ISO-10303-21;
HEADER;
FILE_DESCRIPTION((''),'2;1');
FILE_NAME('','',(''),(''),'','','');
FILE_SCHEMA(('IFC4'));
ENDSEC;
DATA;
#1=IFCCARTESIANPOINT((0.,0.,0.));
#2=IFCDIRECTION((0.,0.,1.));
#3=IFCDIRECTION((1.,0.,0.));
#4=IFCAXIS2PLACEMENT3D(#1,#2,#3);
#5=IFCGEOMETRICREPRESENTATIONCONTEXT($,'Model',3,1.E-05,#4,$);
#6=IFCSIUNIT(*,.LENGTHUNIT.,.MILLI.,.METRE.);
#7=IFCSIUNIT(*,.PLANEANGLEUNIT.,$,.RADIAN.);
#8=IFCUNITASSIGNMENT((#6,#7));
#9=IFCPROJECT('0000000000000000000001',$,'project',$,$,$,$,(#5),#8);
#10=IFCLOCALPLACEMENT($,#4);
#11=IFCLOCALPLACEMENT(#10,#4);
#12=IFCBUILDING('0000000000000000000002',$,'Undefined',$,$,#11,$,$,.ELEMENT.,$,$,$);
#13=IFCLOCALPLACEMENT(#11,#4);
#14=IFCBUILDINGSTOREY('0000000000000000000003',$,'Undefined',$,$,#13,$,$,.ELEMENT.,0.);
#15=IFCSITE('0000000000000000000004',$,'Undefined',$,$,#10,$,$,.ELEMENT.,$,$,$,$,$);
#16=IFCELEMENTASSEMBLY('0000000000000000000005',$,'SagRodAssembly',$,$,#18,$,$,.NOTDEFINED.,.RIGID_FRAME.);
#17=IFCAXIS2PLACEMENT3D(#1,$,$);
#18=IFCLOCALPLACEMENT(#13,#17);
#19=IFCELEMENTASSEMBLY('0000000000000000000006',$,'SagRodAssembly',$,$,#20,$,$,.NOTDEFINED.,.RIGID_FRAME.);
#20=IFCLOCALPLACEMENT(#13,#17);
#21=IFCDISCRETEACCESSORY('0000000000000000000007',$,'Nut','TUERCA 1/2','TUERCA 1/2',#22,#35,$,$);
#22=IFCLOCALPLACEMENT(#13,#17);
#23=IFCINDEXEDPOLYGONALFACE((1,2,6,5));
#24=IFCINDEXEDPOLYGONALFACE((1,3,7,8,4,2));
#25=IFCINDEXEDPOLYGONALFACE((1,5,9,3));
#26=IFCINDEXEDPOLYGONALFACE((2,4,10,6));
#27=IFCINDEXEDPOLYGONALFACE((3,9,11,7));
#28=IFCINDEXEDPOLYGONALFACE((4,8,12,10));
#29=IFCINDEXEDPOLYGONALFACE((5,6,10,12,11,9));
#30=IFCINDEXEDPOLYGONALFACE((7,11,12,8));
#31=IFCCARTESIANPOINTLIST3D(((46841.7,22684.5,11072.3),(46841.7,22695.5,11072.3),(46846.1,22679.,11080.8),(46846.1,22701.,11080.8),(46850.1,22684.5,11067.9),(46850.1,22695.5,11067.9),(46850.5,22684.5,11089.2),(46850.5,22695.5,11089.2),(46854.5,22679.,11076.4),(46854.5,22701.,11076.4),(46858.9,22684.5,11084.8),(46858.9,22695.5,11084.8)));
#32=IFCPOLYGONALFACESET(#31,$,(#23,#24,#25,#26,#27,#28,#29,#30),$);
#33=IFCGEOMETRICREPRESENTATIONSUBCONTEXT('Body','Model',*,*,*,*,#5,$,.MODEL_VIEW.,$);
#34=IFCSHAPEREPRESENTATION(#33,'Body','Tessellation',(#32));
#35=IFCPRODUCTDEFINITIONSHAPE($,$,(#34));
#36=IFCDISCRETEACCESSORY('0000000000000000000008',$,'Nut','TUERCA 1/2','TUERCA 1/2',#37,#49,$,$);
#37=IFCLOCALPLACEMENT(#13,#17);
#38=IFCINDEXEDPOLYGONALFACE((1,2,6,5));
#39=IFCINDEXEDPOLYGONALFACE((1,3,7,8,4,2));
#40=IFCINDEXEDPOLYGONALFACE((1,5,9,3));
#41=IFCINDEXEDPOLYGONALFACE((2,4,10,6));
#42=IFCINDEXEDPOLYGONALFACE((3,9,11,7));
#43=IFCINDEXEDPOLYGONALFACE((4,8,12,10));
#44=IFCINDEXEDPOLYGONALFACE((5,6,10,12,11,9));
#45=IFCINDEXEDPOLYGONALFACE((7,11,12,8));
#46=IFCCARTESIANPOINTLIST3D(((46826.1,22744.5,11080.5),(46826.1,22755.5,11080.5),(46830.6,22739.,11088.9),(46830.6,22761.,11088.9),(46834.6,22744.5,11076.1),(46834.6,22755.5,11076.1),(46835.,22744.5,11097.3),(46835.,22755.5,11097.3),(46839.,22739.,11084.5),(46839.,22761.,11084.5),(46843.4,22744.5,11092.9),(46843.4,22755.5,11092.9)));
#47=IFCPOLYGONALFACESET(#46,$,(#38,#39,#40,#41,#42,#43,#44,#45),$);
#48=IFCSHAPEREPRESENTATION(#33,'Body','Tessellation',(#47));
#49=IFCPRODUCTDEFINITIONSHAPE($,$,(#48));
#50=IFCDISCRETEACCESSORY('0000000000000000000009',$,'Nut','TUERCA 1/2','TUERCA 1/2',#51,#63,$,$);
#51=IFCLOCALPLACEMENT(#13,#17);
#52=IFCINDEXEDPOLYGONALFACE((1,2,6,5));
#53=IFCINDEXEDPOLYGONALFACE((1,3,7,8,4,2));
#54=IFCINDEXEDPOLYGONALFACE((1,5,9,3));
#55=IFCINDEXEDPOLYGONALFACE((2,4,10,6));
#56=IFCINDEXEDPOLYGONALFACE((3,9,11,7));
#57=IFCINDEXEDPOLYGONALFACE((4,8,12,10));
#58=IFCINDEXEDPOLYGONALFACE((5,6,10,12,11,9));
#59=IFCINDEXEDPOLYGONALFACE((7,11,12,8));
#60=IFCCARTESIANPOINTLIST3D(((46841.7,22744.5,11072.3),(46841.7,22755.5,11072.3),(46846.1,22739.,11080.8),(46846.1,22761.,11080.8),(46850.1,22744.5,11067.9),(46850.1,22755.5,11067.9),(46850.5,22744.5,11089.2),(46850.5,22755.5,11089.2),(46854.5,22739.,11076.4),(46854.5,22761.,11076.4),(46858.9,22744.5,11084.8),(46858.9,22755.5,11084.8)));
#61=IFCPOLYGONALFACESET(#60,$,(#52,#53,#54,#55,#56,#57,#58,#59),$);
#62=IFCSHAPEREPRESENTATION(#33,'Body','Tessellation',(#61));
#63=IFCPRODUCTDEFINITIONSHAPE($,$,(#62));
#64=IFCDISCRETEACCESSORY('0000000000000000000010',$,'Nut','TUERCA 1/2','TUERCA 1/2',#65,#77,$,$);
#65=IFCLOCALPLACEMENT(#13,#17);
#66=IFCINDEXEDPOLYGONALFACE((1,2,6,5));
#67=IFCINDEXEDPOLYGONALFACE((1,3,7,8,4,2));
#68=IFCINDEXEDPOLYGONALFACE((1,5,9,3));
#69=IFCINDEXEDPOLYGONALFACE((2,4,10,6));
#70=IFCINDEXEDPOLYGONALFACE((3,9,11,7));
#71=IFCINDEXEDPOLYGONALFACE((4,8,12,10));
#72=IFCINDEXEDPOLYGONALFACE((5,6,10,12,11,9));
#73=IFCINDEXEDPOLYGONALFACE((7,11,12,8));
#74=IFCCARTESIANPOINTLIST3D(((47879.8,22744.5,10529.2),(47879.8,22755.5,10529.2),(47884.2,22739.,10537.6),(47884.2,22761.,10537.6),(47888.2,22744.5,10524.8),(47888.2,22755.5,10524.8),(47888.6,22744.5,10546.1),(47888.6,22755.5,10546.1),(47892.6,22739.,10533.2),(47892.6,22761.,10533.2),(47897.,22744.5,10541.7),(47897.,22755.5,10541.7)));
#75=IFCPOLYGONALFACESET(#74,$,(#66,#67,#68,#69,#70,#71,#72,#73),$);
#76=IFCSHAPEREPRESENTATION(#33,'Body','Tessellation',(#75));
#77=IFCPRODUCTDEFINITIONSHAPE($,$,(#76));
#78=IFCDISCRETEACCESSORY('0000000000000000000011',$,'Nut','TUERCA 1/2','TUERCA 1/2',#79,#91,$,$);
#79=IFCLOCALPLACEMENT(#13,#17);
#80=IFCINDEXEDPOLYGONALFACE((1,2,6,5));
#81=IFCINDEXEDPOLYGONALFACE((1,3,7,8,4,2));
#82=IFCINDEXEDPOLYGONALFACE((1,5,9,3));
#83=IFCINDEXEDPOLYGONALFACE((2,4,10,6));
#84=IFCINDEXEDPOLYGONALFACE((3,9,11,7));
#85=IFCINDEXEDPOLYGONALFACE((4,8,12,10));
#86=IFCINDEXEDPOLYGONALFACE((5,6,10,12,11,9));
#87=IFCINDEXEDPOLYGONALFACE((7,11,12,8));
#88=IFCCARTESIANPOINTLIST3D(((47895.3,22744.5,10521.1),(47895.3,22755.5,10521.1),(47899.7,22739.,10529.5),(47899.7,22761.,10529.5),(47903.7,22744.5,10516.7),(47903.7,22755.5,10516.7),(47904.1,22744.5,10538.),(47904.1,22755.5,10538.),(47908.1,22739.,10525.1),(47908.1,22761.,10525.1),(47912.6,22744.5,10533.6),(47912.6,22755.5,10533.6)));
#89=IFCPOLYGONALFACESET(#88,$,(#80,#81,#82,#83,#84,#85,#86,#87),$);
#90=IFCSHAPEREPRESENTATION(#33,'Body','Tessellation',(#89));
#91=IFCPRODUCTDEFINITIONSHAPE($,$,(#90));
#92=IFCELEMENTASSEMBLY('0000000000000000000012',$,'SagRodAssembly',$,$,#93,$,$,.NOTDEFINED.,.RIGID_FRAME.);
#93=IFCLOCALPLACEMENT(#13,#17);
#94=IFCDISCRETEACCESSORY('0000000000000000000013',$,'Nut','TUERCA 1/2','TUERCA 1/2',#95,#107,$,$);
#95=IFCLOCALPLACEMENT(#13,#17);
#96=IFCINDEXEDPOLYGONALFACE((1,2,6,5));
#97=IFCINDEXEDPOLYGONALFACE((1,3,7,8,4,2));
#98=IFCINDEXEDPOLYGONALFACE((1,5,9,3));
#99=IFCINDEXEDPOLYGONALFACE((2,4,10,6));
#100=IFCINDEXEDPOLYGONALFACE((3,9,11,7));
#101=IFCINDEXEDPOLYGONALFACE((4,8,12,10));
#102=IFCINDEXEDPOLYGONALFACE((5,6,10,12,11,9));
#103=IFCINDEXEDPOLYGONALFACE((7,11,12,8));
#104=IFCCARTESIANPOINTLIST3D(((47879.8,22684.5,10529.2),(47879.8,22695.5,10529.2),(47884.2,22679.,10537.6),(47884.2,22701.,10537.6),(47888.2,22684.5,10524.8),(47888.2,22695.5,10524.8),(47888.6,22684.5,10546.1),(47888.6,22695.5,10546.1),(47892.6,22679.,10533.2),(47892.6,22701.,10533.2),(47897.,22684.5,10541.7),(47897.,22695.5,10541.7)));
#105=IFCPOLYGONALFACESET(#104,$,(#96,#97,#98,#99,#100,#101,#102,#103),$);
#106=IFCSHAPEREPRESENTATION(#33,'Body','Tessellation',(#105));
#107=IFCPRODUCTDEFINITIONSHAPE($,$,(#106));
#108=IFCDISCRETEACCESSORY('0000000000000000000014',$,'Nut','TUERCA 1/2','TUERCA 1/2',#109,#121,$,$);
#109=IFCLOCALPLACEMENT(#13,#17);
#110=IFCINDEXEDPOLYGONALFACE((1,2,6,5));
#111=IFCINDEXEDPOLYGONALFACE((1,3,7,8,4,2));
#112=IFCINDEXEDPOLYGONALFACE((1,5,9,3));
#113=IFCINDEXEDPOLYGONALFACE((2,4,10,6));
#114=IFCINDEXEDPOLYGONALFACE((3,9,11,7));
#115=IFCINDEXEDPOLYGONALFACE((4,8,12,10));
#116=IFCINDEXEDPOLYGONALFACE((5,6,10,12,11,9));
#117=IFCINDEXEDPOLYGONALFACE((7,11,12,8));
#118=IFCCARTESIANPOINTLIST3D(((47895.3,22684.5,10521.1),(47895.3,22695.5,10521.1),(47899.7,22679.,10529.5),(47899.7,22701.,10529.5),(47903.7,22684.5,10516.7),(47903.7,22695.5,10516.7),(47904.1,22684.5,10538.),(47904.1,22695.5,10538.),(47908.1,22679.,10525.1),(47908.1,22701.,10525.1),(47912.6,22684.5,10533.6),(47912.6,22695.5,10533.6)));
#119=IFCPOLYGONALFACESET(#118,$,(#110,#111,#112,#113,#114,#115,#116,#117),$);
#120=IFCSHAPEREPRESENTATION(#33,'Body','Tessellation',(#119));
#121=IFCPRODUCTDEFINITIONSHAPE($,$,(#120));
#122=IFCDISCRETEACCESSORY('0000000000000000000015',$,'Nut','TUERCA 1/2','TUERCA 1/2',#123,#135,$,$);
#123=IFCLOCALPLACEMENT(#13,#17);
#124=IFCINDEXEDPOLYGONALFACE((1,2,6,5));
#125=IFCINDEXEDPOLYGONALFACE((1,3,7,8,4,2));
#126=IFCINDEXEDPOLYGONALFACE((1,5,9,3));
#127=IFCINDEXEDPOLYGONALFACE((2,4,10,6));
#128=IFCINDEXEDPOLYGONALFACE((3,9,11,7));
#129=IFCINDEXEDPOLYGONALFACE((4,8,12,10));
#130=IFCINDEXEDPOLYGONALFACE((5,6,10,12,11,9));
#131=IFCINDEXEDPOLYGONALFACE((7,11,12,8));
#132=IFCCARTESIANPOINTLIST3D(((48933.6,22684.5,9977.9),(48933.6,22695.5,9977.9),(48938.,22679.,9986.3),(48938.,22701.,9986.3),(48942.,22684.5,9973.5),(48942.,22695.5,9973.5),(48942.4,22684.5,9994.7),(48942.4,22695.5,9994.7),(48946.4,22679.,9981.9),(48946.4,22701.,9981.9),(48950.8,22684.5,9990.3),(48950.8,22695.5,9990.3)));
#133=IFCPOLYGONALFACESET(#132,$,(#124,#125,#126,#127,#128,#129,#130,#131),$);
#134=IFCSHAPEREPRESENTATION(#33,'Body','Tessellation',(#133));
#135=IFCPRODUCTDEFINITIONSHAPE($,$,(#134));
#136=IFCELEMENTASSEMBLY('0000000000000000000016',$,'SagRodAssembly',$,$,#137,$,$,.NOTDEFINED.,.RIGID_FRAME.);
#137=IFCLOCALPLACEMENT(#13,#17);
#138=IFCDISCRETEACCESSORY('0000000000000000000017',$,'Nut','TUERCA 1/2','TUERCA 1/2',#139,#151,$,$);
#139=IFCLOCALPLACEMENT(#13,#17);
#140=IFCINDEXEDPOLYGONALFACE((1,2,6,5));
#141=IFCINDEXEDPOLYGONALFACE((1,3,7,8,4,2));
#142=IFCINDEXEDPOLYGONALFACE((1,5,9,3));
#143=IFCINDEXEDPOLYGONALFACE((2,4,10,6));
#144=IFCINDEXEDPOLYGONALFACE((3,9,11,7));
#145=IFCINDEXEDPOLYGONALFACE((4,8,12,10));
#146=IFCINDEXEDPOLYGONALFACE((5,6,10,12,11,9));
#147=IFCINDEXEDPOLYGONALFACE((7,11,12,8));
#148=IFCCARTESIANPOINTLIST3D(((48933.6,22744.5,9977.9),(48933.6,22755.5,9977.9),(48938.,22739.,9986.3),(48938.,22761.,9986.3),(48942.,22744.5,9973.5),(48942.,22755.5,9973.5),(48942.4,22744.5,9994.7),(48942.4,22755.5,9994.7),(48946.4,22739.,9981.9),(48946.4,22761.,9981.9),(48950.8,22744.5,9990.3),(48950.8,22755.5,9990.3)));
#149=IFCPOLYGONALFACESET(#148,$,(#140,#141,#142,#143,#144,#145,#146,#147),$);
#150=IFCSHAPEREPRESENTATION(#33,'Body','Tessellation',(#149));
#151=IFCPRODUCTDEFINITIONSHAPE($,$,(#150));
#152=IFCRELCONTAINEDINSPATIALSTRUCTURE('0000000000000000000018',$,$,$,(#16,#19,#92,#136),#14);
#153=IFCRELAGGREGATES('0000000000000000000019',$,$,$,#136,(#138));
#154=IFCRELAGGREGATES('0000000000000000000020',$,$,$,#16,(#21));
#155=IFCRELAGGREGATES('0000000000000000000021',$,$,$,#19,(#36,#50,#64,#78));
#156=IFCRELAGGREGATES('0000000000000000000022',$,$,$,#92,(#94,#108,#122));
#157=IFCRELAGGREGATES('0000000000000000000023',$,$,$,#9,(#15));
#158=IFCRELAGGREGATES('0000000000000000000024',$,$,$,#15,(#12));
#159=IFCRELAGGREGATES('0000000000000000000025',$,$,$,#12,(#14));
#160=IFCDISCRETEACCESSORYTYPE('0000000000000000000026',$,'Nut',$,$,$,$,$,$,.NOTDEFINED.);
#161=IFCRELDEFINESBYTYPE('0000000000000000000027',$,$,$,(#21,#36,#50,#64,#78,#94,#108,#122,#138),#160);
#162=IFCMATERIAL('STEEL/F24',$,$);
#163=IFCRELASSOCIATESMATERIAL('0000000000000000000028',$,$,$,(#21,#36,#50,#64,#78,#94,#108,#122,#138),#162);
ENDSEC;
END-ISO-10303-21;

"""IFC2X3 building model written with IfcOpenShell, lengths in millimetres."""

from ifc_helpers import new_model, si_unit, frame, origin_with_axes, place, context, subcontext, project, spatial, polyline, outline, extrude, material, type_object, element, aggregate, save


model = new_model("IFC2X3")

# Units and contexts
model_context = context("Model", 3, precision=1e-05, world=origin_with_axes())
body_context = subcontext(model_context, "Body", "Model", "MODEL_VIEW")
ifc_project = project(units=[si_unit("LENGTHUNIT", "METRE", prefix="MILLI"), si_unit("PLANEANGLEUNIT", "RADIAN")], contexts=[model_context])

# Site, building, storey
site_placement = place(None, origin_with_axes())
site = spatial("IfcSite", under=ifc_project, at=site_placement, Name="Undefined", CompositionType="ELEMENT")
building_placement = place(site_placement, origin_with_axes())
building = spatial("IfcBuilding", under=site, at=building_placement, Name="Undefined", CompositionType="ELEMENT")
storey_placement = place(building_placement, origin_with_axes())
storey = spatial("IfcBuildingStorey", under=building, at=storey_placement, Name="Undefined", CompositionType="ELEMENT", Elevation=0.0)

# Element assemblies
assembly_1_placement = place(storey_placement, origin_with_axes())
assembly_1 = element("IfcElementAssembly", 1, at=assembly_1_placement, inside=storey, Name="SagRodAssembly", AssemblyPlace="NOTDEFINED", PredefinedType="RIGID_FRAME")
ifc_material_1 = material(Name="STEEL/F24")
assembly_2_placement = place(storey_placement, origin_with_axes())
assembly_2 = element("IfcElementAssembly", 2, at=assembly_2_placement, inside=storey, Name="SagRodAssembly", AssemblyPlace="NOTDEFINED", PredefinedType="RIGID_FRAME")

# Discrete accessories
discrete_accessory_type_1 = type_object("IfcDiscreteAccessoryType", Name="Nut")
discrete_accessory_1_placement = place(assembly_1_placement, frame((46854.5, 22690.0, 11076.4), z_axis=(-0.463578, 0.0, -0.886056), x_axis=(-0.886056, 0.0, 0.463578)))
discrete_accessory_1 = element("IfcDiscreteAccessory", 3, at=discrete_accessory_1_placement, type_object=discrete_accessory_type_1, material=ifc_material_1, Name="Nut", Description="TUERCA 1/2", ObjectType="TUERCA 1/2", context=body_context, shape_type="SweptSolid", body=[
    extrude(outline(polyline([(-5.5, 9.5), (5.5, 9.5), (11.0, 0.0), (5.5, -9.5), (-5.5, -9.5), (-11.0, 0.0), (-5.5, 9.5)])), frame((9.5, 0.0, 0.0), z_axis=(-1.0, 0.0, 0.0), x_axis=(0.0, -1.0, 0.0)), (0.0, 0.0, 1.0), 9.5),
])
discrete_accessory_2_placement = place(assembly_2_placement, frame((46839.0, 22750.0, 11084.5), z_axis=(-0.463578, 0.0, -0.886056), x_axis=(-0.886056, 0.0, 0.463578)))
discrete_accessory_2 = element("IfcDiscreteAccessory", 4, at=discrete_accessory_2_placement, type_object=discrete_accessory_type_1, material=ifc_material_1, Name="Nut", Description="TUERCA 1/2", ObjectType="TUERCA 1/2", context=body_context, shape_type="SweptSolid", body=[
    extrude(outline(polyline([(-5.5, 9.5), (5.5, 9.5), (11.0, 0.0), (5.5, -9.5), (-5.5, -9.5), (-11.0, 0.0), (-5.5, 9.5)])), frame((9.5, 0.0, 0.0), z_axis=(-1.0, 0.0, 0.0), x_axis=(0.0, -1.0, 0.0)), (0.0, 0.0, 1.0), 9.5),
])
discrete_accessory_3_placement = place(assembly_2_placement, frame((46854.5, 22750.0, 11076.4), z_axis=(-0.463578, 0.0, -0.886056), x_axis=(-0.886056, 0.0, 0.463578)))
discrete_accessory_3 = element("IfcDiscreteAccessory", 5, at=discrete_accessory_3_placement, type_object=discrete_accessory_type_1, material=ifc_material_1, Name="Nut", Description="TUERCA 1/2", ObjectType="TUERCA 1/2", context=body_context, shape_type="SweptSolid", body=[
    extrude(outline(polyline([(-5.5, 9.5), (5.5, 9.5), (11.0, 0.0), (5.5, -9.5), (-5.5, -9.5), (-11.0, 0.0), (-5.5, 9.5)])), frame((9.5, 0.0, 0.0), z_axis=(-1.0, 0.0, 0.0), x_axis=(0.0, -1.0, 0.0)), (0.0, 0.0, 1.0), 9.5),
])
discrete_accessory_4_placement = place(assembly_2_placement, frame((47892.6, 22750.0, 10533.2), z_axis=(-0.463578, 0.0, -0.886056), x_axis=(-0.886056, 0.0, 0.463578)))
discrete_accessory_4 = element("IfcDiscreteAccessory", 6, at=discrete_accessory_4_placement, type_object=discrete_accessory_type_1, material=ifc_material_1, Name="Nut", Description="TUERCA 1/2", ObjectType="TUERCA 1/2", context=body_context, shape_type="SweptSolid", body=[
    extrude(outline(polyline([(-5.5, 9.5), (5.5, 9.5), (11.0, 0.0), (5.5, -9.5), (-5.5, -9.5), (-11.0, 0.0), (-5.5, 9.5)])), frame((9.5, 0.0, 0.0), z_axis=(-1.0, 0.0, 0.0), x_axis=(0.0, -1.0, 0.0)), (0.0, 0.0, 1.0), 9.5),
])
discrete_accessory_5_placement = place(assembly_2_placement, frame((47908.1, 22750.0, 10525.1), z_axis=(-0.463578, 0.0, -0.886056), x_axis=(-0.886056, 0.0, 0.463578)))
discrete_accessory_5 = element("IfcDiscreteAccessory", 7, at=discrete_accessory_5_placement, type_object=discrete_accessory_type_1, material=ifc_material_1, Name="Nut", Description="TUERCA 1/2", ObjectType="TUERCA 1/2", context=body_context, shape_type="SweptSolid", body=[
    extrude(outline(polyline([(-5.5, 9.5), (5.5, 9.5), (11.0, 0.0), (5.5, -9.5), (-5.5, -9.5), (-11.0, 0.0), (-5.5, 9.5)])), frame((9.5, 0.0, 0.0), z_axis=(-1.0, 0.0, 0.0), x_axis=(0.0, -1.0, 0.0)), (0.0, 0.0, 1.0), 9.5),
])

# Element assembly, discrete accessories
assembly_3_placement = place(storey_placement, origin_with_axes())
assembly_3 = element("IfcElementAssembly", 8, at=assembly_3_placement, inside=storey, Name="SagRodAssembly", AssemblyPlace="NOTDEFINED", PredefinedType="RIGID_FRAME")
discrete_accessory_6_placement = place(assembly_3_placement, frame((47892.6, 22690.0, 10533.2), z_axis=(-0.463578, 0.0, -0.886056), x_axis=(-0.886056, 0.0, 0.463578)))
discrete_accessory_6 = element("IfcDiscreteAccessory", 9, at=discrete_accessory_6_placement, type_object=discrete_accessory_type_1, material=ifc_material_1, Name="Nut", Description="TUERCA 1/2", ObjectType="TUERCA 1/2", context=body_context, shape_type="SweptSolid", body=[
    extrude(outline(polyline([(-5.5, 9.5), (5.5, 9.5), (11.0, 0.0), (5.5, -9.5), (-5.5, -9.5), (-11.0, 0.0), (-5.5, 9.5)])), frame((9.5, 0.0, 0.0), z_axis=(-1.0, 0.0, 0.0), x_axis=(0.0, -1.0, 0.0)), (0.0, 0.0, 1.0), 9.5),
])
discrete_accessory_7_placement = place(assembly_3_placement, frame((47908.1, 22690.0, 10525.1), z_axis=(-0.463578, 0.0, -0.886056), x_axis=(-0.886056, 0.0, 0.463578)))
discrete_accessory_7 = element("IfcDiscreteAccessory", 10, at=discrete_accessory_7_placement, type_object=discrete_accessory_type_1, material=ifc_material_1, Name="Nut", Description="TUERCA 1/2", ObjectType="TUERCA 1/2", context=body_context, shape_type="SweptSolid", body=[
    extrude(outline(polyline([(-5.5, 9.5), (5.5, 9.5), (11.0, 0.0), (5.5, -9.5), (-5.5, -9.5), (-11.0, 0.0), (-5.5, 9.5)])), frame((9.5, 0.0, 0.0), z_axis=(-1.0, 0.0, 0.0), x_axis=(0.0, -1.0, 0.0)), (0.0, 0.0, 1.0), 9.5),
])
discrete_accessory_8_placement = place(assembly_3_placement, frame((48946.4, 22690.0, 9981.9), z_axis=(-0.463578, 0.0, -0.886056), x_axis=(-0.886056, 0.0, 0.463578)))
discrete_accessory_8 = element("IfcDiscreteAccessory", 11, at=discrete_accessory_8_placement, type_object=discrete_accessory_type_1, material=ifc_material_1, Name="Nut", Description="TUERCA 1/2", ObjectType="TUERCA 1/2", context=body_context, shape_type="SweptSolid", body=[
    extrude(outline(polyline([(-5.5, 9.5), (5.5, 9.5), (11.0, 0.0), (5.5, -9.5), (-5.5, -9.5), (-11.0, 0.0), (-5.5, 9.5)])), frame((9.5, 0.0, 0.0), z_axis=(-1.0, 0.0, 0.0), x_axis=(0.0, -1.0, 0.0)), (0.0, 0.0, 1.0), 9.5),
])

# Element assembly, discrete accessory
assembly_4_placement = place(storey_placement, origin_with_axes())
assembly_4 = element("IfcElementAssembly", 12, at=assembly_4_placement, inside=storey, Name="SagRodAssembly", AssemblyPlace="NOTDEFINED", PredefinedType="RIGID_FRAME")
discrete_accessory_9_placement = place(assembly_4_placement, frame((48946.4, 22750.0, 9981.9), z_axis=(-0.463578, 0.0, -0.886056), x_axis=(-0.886056, 0.0, 0.463578)))
discrete_accessory_9 = element("IfcDiscreteAccessory", 13, at=discrete_accessory_9_placement, type_object=discrete_accessory_type_1, material=ifc_material_1, Name="Nut", Description="TUERCA 1/2", ObjectType="TUERCA 1/2", context=body_context, shape_type="SweptSolid", body=[
    extrude(outline(polyline([(-5.5, 9.5), (5.5, 9.5), (11.0, 0.0), (5.5, -9.5), (-5.5, -9.5), (-11.0, 0.0), (-5.5, 9.5)])), frame((9.5, 0.0, 0.0), z_axis=(-1.0, 0.0, 0.0), x_axis=(0.0, -1.0, 0.0)), (0.0, 0.0, 1.0), 9.5),
])
aggregate(assembly_4, [discrete_accessory_9])

aggregate(assembly_1, [discrete_accessory_1])
aggregate(assembly_2, [discrete_accessory_2, discrete_accessory_3, discrete_accessory_4, discrete_accessory_5])
aggregate(assembly_3, [discrete_accessory_6, discrete_accessory_7, discrete_accessory_8])

save(model, "model.ifc")
